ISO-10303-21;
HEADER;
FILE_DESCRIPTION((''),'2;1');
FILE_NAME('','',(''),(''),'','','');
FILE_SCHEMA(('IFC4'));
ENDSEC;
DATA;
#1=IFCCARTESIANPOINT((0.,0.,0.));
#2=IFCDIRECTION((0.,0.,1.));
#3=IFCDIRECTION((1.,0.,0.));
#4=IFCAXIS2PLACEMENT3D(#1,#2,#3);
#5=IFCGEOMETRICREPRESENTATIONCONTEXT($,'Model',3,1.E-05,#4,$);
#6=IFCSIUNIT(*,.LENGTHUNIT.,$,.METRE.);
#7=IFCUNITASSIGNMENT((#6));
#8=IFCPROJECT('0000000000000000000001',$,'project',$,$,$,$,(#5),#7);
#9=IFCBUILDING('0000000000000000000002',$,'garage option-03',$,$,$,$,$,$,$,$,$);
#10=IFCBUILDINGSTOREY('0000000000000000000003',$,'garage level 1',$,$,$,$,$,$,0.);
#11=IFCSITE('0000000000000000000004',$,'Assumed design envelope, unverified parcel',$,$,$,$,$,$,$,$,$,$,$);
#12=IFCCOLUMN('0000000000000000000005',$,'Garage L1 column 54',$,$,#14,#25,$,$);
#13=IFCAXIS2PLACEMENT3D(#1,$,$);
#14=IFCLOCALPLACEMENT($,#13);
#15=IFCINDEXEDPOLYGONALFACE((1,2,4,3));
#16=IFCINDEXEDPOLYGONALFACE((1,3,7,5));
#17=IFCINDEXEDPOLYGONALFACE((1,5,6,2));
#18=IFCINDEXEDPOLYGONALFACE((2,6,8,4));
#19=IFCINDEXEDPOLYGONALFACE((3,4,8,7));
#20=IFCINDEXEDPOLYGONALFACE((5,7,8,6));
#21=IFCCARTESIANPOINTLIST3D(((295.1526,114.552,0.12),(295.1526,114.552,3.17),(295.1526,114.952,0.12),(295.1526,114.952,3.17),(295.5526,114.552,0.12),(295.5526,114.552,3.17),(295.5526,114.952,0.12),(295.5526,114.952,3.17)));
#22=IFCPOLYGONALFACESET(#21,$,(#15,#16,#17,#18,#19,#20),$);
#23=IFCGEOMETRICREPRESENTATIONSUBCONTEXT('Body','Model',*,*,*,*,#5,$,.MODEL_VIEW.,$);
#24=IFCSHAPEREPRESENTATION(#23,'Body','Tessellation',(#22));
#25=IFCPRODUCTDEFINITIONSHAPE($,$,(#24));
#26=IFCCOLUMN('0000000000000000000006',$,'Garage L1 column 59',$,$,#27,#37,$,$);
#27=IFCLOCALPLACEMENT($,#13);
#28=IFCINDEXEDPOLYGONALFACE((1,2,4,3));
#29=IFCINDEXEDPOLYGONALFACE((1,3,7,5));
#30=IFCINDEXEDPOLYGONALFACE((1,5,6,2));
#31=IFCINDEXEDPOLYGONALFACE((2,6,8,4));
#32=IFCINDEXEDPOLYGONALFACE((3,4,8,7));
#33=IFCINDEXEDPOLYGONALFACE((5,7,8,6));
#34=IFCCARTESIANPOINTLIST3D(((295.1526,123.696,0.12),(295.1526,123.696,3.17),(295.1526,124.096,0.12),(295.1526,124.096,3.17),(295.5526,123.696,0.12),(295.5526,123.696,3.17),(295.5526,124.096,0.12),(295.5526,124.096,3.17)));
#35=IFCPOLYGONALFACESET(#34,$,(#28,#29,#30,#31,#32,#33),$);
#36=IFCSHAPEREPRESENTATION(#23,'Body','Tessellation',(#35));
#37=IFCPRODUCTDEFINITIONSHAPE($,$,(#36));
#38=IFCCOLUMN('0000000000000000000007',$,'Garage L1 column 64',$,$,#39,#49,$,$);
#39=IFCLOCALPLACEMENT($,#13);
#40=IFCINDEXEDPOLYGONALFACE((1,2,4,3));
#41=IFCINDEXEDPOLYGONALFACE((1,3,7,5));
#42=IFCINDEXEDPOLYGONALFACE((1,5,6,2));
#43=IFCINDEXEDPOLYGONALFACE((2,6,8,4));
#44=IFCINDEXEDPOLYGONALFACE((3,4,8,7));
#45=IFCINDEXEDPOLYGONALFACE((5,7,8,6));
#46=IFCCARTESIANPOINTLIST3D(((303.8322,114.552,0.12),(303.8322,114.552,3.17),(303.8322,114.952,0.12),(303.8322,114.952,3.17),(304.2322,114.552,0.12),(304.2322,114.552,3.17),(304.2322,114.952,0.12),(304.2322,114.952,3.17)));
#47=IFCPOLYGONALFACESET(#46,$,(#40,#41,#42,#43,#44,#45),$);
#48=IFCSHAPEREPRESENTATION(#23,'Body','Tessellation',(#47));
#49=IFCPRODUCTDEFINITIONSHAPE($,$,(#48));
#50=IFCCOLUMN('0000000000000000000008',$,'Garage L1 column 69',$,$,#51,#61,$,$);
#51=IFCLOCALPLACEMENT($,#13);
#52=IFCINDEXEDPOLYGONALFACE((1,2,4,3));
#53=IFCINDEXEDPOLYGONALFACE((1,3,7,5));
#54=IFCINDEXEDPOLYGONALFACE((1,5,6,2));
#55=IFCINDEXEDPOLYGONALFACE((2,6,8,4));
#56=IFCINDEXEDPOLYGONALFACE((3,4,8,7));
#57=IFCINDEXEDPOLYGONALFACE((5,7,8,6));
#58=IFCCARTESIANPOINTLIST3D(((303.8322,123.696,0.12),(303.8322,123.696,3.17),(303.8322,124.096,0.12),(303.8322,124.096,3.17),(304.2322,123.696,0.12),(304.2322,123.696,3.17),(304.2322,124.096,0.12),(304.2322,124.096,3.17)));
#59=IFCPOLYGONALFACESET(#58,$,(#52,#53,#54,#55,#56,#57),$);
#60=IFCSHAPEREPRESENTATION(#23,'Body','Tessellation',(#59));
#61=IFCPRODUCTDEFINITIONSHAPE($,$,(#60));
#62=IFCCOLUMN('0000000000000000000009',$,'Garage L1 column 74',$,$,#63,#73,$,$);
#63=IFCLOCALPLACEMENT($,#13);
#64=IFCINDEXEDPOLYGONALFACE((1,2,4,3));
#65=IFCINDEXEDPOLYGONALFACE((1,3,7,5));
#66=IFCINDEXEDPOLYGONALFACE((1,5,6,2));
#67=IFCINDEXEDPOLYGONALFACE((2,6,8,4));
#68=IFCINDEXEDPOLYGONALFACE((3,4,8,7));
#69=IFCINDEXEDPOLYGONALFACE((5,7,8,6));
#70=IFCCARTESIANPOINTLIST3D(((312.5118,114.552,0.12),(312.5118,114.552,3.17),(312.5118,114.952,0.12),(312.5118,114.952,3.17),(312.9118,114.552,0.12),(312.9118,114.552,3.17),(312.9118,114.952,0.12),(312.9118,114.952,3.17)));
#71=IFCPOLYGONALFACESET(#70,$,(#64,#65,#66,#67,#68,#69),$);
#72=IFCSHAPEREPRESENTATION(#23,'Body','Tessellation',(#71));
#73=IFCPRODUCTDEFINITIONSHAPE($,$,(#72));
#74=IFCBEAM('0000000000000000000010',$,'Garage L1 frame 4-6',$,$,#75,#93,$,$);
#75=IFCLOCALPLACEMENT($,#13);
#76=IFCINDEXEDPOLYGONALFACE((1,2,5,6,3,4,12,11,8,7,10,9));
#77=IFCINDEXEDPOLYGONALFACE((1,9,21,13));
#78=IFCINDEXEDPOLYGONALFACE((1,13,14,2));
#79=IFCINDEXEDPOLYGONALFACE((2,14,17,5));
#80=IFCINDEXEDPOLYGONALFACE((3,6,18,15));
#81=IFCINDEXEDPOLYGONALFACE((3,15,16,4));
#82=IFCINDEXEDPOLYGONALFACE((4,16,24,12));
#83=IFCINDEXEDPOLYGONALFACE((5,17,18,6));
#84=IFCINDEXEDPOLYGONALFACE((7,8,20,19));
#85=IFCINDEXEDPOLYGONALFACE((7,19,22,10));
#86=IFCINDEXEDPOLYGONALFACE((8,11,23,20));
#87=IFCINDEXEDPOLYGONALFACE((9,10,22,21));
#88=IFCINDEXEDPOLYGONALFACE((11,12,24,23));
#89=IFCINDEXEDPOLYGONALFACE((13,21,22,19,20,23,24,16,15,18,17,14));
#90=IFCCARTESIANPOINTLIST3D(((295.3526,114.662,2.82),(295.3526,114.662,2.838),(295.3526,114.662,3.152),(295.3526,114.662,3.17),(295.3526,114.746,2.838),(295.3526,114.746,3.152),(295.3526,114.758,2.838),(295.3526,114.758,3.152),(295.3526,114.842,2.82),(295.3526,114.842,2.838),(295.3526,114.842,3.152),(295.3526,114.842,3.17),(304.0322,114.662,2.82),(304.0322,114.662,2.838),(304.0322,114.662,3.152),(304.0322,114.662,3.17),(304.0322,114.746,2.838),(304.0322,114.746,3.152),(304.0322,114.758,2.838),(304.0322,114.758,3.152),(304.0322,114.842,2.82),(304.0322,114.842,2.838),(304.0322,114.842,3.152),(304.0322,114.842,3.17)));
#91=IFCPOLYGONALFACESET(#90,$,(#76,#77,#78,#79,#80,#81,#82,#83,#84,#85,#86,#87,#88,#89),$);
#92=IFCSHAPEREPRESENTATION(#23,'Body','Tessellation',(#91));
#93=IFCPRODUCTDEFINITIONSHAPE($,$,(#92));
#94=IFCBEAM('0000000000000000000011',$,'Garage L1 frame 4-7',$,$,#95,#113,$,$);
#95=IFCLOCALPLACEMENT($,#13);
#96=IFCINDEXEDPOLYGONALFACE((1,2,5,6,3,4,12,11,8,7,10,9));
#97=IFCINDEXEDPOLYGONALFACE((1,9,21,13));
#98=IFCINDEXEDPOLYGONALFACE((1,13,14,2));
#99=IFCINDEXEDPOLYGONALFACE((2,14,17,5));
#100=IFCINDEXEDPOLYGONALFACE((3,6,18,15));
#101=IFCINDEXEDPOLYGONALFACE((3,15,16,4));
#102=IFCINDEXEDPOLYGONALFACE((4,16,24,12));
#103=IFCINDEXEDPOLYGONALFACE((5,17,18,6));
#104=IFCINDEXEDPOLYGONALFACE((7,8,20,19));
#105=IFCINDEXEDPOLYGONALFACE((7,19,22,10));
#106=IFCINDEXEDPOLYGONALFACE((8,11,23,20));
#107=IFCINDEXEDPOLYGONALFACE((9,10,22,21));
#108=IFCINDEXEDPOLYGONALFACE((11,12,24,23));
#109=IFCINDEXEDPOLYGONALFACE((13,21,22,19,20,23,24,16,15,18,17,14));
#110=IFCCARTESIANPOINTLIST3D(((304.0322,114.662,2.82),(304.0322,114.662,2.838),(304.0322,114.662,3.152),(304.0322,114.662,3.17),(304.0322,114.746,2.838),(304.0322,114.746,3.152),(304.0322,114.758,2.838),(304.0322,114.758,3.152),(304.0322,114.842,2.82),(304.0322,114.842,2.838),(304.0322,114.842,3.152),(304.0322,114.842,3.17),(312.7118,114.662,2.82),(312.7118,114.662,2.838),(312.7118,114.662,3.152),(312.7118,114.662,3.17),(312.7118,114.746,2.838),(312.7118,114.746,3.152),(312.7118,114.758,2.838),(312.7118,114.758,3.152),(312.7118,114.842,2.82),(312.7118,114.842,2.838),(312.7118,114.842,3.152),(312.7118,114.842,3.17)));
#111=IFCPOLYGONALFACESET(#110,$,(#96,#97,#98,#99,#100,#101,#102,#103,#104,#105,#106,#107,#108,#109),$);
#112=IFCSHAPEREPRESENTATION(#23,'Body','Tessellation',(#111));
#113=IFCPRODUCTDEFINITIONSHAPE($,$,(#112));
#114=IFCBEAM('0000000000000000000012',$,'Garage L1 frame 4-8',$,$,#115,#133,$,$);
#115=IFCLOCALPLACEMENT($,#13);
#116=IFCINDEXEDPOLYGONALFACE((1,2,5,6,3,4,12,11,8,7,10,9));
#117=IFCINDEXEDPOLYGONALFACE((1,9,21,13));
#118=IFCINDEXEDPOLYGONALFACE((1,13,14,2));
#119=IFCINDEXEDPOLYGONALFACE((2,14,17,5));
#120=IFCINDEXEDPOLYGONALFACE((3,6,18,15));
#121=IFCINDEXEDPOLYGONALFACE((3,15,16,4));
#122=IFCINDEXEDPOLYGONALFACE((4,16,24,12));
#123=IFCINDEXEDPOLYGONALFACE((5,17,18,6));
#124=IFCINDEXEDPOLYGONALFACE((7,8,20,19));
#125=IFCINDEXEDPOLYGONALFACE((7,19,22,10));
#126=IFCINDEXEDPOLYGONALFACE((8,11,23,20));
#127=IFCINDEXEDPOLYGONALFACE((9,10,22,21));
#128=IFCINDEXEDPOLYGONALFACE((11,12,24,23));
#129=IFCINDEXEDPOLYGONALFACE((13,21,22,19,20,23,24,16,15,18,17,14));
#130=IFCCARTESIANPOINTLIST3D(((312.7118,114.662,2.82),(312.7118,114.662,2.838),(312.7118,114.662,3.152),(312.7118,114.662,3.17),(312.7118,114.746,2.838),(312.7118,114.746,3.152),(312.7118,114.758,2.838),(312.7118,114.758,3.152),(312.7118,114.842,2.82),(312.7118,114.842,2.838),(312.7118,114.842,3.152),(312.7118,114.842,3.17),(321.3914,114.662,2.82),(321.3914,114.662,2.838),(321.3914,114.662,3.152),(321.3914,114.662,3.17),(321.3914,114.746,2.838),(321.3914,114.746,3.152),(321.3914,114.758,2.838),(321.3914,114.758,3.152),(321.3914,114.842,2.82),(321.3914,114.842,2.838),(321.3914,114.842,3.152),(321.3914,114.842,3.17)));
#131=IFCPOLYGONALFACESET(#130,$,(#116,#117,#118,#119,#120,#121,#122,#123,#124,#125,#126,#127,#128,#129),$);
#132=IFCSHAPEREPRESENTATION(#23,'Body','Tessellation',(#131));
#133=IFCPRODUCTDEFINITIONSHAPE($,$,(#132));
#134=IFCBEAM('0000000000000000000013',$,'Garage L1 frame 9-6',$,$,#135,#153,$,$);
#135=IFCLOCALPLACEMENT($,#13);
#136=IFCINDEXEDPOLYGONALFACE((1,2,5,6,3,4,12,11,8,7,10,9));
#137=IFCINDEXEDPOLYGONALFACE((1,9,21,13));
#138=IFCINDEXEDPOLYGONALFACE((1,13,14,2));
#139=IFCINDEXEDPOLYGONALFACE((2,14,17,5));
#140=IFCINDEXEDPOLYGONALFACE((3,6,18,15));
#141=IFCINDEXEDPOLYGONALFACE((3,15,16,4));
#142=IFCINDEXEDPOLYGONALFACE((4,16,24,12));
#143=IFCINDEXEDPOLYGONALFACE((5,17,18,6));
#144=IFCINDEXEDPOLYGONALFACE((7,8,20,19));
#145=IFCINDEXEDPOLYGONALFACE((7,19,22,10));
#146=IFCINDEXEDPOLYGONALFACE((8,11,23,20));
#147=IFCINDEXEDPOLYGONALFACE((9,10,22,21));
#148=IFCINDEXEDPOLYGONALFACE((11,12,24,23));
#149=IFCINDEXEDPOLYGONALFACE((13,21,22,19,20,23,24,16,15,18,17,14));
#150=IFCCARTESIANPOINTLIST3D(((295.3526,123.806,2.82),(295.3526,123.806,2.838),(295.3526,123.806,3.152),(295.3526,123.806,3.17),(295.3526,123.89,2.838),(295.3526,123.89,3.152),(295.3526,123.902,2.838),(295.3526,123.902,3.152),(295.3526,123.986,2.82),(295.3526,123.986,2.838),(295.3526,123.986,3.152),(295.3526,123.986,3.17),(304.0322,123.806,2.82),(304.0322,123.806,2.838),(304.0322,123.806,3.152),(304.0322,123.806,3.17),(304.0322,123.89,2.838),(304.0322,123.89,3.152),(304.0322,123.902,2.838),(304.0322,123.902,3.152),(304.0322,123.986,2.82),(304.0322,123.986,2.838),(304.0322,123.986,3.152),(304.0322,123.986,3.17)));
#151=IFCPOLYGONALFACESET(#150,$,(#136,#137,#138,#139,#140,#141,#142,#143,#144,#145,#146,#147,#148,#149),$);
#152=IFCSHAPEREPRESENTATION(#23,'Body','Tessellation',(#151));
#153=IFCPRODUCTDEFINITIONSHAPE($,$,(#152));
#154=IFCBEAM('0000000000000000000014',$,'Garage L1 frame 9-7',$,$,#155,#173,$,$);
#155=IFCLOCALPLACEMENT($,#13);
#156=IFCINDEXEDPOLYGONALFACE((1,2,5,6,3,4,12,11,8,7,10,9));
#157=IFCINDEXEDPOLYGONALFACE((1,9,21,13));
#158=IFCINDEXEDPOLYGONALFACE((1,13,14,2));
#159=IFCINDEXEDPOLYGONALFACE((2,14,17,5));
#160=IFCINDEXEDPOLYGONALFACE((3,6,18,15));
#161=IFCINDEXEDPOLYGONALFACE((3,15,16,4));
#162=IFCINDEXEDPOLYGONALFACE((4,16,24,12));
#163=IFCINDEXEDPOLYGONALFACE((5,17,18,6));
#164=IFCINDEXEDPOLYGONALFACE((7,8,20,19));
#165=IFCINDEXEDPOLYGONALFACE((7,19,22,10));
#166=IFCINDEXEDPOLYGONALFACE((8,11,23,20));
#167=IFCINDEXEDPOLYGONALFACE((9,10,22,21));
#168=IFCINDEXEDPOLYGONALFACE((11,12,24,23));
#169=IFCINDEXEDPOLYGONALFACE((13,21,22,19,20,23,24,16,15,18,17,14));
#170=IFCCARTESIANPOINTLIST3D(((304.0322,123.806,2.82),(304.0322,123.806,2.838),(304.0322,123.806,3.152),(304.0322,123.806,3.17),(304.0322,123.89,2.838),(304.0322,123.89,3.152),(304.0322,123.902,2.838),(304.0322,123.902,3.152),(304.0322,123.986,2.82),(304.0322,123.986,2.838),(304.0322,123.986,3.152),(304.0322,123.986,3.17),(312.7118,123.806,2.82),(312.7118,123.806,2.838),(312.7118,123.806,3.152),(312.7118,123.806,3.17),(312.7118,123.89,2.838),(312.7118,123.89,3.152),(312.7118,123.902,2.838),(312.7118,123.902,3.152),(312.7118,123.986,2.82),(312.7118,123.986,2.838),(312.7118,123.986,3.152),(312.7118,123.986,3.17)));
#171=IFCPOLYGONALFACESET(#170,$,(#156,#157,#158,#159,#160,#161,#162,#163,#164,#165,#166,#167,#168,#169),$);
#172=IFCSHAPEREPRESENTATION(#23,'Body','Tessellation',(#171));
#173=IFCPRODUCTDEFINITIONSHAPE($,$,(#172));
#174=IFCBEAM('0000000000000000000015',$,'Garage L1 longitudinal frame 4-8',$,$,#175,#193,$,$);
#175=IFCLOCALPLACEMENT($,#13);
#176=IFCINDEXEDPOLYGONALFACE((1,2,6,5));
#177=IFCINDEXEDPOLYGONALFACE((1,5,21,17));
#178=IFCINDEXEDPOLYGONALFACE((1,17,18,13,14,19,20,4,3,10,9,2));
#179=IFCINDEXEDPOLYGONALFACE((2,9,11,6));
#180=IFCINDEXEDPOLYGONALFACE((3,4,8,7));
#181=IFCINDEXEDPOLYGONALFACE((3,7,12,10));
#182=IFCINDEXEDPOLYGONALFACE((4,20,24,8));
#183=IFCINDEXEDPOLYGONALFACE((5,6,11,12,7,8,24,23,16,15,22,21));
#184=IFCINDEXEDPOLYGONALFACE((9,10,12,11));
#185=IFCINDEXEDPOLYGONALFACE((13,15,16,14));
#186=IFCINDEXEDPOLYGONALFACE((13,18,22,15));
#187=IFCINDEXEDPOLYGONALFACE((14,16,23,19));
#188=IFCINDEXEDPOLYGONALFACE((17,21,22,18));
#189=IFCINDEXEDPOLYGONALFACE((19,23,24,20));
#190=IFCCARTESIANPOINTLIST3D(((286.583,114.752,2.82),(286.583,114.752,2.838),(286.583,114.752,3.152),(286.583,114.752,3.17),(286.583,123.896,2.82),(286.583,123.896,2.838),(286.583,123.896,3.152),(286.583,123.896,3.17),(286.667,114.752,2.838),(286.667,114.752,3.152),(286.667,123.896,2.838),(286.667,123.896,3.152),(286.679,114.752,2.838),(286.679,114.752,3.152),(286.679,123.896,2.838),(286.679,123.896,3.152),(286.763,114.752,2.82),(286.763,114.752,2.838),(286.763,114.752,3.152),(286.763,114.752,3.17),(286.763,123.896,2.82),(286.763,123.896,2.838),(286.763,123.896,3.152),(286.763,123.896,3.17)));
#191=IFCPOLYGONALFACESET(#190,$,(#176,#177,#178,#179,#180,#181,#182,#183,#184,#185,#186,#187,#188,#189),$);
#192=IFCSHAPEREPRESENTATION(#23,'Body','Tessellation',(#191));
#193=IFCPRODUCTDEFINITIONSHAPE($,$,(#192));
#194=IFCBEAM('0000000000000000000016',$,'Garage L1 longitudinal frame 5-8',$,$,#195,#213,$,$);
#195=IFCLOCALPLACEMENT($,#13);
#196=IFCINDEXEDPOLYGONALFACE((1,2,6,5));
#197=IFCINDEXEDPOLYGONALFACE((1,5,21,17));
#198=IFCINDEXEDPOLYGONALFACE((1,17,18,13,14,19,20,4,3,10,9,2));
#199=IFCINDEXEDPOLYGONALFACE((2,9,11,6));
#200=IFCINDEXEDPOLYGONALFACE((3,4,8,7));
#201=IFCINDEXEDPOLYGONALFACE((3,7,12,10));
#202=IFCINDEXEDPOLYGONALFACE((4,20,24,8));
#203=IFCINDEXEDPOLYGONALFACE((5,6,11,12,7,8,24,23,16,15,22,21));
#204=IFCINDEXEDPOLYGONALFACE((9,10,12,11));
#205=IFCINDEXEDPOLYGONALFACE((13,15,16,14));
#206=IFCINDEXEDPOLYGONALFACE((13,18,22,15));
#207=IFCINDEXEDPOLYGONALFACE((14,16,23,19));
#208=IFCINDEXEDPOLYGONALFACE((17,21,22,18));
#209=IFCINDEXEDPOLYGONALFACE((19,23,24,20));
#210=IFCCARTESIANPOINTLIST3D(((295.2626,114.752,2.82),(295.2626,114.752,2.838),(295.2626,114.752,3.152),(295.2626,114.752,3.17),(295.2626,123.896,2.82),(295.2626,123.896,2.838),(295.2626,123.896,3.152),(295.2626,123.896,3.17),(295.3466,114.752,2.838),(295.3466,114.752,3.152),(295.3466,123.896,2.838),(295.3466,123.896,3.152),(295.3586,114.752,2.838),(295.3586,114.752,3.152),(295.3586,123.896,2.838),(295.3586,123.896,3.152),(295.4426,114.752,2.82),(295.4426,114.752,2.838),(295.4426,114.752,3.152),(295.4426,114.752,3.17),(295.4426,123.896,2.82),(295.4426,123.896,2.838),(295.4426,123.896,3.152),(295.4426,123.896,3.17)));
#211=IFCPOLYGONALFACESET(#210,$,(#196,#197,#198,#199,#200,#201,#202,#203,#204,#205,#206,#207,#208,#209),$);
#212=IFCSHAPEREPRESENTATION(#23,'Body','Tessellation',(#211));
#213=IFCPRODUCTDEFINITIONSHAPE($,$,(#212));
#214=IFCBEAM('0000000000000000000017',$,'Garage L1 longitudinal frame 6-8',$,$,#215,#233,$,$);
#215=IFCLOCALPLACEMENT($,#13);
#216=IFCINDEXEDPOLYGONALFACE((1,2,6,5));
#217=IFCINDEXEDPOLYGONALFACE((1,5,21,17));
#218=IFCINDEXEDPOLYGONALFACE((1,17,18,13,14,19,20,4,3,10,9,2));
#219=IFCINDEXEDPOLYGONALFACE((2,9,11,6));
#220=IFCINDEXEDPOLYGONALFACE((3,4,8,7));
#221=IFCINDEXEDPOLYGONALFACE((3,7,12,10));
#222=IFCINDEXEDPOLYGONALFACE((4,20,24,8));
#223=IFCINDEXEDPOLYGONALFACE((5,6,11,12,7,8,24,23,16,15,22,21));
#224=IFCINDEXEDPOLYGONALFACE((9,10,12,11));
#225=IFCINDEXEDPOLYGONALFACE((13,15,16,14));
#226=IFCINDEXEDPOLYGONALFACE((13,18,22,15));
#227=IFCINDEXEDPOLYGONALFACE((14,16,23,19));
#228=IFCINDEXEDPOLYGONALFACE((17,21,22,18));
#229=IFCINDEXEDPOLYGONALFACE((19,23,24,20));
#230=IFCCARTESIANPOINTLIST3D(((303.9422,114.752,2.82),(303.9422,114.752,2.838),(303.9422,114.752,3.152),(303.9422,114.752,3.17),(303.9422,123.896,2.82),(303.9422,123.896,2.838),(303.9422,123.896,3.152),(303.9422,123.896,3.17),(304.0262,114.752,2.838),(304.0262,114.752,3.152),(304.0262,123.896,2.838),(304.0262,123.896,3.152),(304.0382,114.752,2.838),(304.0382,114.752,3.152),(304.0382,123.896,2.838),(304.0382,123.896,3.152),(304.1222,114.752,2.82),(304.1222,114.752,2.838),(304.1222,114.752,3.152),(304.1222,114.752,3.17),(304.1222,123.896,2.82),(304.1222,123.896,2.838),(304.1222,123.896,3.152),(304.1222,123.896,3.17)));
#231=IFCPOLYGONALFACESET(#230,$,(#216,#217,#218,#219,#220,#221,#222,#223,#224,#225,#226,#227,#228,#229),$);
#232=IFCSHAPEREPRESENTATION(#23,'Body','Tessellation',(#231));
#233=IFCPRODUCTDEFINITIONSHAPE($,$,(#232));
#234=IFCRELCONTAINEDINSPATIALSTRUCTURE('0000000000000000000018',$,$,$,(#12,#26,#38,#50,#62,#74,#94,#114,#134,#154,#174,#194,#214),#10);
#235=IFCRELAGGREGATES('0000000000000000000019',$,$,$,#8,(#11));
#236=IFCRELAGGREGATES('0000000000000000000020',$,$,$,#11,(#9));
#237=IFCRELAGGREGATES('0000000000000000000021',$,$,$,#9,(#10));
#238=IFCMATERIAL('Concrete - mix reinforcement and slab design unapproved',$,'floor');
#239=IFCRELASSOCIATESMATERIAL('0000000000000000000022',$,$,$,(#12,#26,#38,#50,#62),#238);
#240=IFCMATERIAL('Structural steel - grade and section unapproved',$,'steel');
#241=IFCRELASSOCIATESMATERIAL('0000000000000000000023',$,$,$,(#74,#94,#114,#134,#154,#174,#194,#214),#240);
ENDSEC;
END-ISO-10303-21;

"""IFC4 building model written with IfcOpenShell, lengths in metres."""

from ifc_helpers import new_model, si_unit, frame, origin_with_axes, place, context, subcontext, project, spatial, rectangle, i_section, extrude, material, element, save


model = new_model("IFC4")

# Units and contexts
model_context = context("Model", 3, precision=1e-05, world=origin_with_axes())
body_context = subcontext(model_context, "Body", "Model", "MODEL_VIEW")
ifc_project = project(units=[si_unit("LENGTHUNIT", "METRE")], contexts=[model_context])

# Site, building, storey
site = spatial("IfcSite", under=ifc_project, Name="Assumed design envelope, unverified parcel")
building = spatial("IfcBuilding", under=site, Name="garage option-03")
storey = spatial("IfcBuildingStorey", under=building, Name="garage level 1", Elevation=0.0)

# Columns
ifc_material_1 = material(Name="Concrete - mix reinforcement and slab design unapproved", Category="floor")
for number, where, z_axis, x_axis, name in (
    (1, (295.3526, 114.752, 0.12), (0.0, 0.0, 1.0), (1.0, 0.0, 0.0), "Garage L1 column 54"),
    (2, (295.3526, 123.896, 0.12), (0.0, 0.0, 1.0), (1.0, 0.0, 0.0), "Garage L1 column 59"),
    (3, (304.0322, 114.752, 0.12), (0.0, 0.0, 1.0), (1.0, 0.0, 0.0), "Garage L1 column 64"),
    (4, (304.0322, 123.896, 0.12), (0.0, 0.0, 1.0), (1.0, 0.0, 0.0), "Garage L1 column 69"),
    (5, (312.7118, 114.752, 0.12), (0.0, 0.0, 1.0), (1.0, 0.0, 0.0), "Garage L1 column 74"),
):
    element("IfcColumn", number, at=place(None, frame(where, z_axis=z_axis, x_axis=x_axis)), inside=storey, material=ifc_material_1, Name=name, context=body_context, shape_type="SweptSolid", body=[
        extrude(rectangle(XDim=0.4, YDim=0.4), origin_with_axes(), (0.0, 0.0, 1.0), 3.05),
    ])

# Beams
ifc_material_2 = material(Name="Structural steel - grade and section unapproved", Category="steel")
for number, where, z_axis, x_axis, name in (
    (6, (295.3526, 114.752, 2.995), (1.0, 0.0, 0.0), (0.0, 1.0, 0.0), "Garage L1 frame 4-6"),
    (7, (304.0322, 114.752, 2.995), (1.0, 0.0, 0.0), (0.0, 1.0, 0.0), "Garage L1 frame 4-7"),
    (8, (312.7118, 114.752, 2.995), (1.0, 0.0, 0.0), (0.0, 1.0, 0.0), "Garage L1 frame 4-8"),
    (9, (295.3526, 123.896, 2.995), (1.0, 0.0, 0.0), (0.0, 1.0, 0.0), "Garage L1 frame 9-6"),
    (10, (304.0322, 123.896, 2.995), (1.0, 0.0, 0.0), (0.0, 1.0, 0.0), "Garage L1 frame 9-7"),
):
    element("IfcBeam", number, at=place(None, frame(where, z_axis=z_axis, x_axis=x_axis)), inside=storey, material=ifc_material_2, Name=name, context=body_context, shape_type="SweptSolid", body=[
        extrude(i_section(OverallWidth=0.18, OverallDepth=0.35, WebThickness=0.012, FlangeThickness=0.018, FilletRadius=0.0), origin_with_axes(), (0.0, 0.0, 1.0), 8.6796),
    ])
for number, where, z_axis, x_axis, name in (
    (11, (286.673, 114.752, 2.995), (0.0, 1.0, 0.0), (-1.0, 0.0, 0.0), "Garage L1 longitudinal frame 4-8"),
    (12, (295.3526, 114.752, 2.995), (0.0, 1.0, 0.0), (-1.0, 0.0, 0.0), "Garage L1 longitudinal frame 5-8"),
    (13, (304.0322, 114.752, 2.995), (0.0, 1.0, 0.0), (-1.0, 0.0, 0.0), "Garage L1 longitudinal frame 6-8"),
):
    element("IfcBeam", number, at=place(None, frame(where, z_axis=z_axis, x_axis=x_axis)), inside=storey, material=ifc_material_2, Name=name, context=body_context, shape_type="SweptSolid", body=[
        extrude(i_section(OverallWidth=0.18, OverallDepth=0.35, WebThickness=0.012, FlangeThickness=0.018, FilletRadius=0.0), origin_with_axes(), (0.0, 0.0, 1.0), 9.144),
    ])

save(model, "model.ifc")
